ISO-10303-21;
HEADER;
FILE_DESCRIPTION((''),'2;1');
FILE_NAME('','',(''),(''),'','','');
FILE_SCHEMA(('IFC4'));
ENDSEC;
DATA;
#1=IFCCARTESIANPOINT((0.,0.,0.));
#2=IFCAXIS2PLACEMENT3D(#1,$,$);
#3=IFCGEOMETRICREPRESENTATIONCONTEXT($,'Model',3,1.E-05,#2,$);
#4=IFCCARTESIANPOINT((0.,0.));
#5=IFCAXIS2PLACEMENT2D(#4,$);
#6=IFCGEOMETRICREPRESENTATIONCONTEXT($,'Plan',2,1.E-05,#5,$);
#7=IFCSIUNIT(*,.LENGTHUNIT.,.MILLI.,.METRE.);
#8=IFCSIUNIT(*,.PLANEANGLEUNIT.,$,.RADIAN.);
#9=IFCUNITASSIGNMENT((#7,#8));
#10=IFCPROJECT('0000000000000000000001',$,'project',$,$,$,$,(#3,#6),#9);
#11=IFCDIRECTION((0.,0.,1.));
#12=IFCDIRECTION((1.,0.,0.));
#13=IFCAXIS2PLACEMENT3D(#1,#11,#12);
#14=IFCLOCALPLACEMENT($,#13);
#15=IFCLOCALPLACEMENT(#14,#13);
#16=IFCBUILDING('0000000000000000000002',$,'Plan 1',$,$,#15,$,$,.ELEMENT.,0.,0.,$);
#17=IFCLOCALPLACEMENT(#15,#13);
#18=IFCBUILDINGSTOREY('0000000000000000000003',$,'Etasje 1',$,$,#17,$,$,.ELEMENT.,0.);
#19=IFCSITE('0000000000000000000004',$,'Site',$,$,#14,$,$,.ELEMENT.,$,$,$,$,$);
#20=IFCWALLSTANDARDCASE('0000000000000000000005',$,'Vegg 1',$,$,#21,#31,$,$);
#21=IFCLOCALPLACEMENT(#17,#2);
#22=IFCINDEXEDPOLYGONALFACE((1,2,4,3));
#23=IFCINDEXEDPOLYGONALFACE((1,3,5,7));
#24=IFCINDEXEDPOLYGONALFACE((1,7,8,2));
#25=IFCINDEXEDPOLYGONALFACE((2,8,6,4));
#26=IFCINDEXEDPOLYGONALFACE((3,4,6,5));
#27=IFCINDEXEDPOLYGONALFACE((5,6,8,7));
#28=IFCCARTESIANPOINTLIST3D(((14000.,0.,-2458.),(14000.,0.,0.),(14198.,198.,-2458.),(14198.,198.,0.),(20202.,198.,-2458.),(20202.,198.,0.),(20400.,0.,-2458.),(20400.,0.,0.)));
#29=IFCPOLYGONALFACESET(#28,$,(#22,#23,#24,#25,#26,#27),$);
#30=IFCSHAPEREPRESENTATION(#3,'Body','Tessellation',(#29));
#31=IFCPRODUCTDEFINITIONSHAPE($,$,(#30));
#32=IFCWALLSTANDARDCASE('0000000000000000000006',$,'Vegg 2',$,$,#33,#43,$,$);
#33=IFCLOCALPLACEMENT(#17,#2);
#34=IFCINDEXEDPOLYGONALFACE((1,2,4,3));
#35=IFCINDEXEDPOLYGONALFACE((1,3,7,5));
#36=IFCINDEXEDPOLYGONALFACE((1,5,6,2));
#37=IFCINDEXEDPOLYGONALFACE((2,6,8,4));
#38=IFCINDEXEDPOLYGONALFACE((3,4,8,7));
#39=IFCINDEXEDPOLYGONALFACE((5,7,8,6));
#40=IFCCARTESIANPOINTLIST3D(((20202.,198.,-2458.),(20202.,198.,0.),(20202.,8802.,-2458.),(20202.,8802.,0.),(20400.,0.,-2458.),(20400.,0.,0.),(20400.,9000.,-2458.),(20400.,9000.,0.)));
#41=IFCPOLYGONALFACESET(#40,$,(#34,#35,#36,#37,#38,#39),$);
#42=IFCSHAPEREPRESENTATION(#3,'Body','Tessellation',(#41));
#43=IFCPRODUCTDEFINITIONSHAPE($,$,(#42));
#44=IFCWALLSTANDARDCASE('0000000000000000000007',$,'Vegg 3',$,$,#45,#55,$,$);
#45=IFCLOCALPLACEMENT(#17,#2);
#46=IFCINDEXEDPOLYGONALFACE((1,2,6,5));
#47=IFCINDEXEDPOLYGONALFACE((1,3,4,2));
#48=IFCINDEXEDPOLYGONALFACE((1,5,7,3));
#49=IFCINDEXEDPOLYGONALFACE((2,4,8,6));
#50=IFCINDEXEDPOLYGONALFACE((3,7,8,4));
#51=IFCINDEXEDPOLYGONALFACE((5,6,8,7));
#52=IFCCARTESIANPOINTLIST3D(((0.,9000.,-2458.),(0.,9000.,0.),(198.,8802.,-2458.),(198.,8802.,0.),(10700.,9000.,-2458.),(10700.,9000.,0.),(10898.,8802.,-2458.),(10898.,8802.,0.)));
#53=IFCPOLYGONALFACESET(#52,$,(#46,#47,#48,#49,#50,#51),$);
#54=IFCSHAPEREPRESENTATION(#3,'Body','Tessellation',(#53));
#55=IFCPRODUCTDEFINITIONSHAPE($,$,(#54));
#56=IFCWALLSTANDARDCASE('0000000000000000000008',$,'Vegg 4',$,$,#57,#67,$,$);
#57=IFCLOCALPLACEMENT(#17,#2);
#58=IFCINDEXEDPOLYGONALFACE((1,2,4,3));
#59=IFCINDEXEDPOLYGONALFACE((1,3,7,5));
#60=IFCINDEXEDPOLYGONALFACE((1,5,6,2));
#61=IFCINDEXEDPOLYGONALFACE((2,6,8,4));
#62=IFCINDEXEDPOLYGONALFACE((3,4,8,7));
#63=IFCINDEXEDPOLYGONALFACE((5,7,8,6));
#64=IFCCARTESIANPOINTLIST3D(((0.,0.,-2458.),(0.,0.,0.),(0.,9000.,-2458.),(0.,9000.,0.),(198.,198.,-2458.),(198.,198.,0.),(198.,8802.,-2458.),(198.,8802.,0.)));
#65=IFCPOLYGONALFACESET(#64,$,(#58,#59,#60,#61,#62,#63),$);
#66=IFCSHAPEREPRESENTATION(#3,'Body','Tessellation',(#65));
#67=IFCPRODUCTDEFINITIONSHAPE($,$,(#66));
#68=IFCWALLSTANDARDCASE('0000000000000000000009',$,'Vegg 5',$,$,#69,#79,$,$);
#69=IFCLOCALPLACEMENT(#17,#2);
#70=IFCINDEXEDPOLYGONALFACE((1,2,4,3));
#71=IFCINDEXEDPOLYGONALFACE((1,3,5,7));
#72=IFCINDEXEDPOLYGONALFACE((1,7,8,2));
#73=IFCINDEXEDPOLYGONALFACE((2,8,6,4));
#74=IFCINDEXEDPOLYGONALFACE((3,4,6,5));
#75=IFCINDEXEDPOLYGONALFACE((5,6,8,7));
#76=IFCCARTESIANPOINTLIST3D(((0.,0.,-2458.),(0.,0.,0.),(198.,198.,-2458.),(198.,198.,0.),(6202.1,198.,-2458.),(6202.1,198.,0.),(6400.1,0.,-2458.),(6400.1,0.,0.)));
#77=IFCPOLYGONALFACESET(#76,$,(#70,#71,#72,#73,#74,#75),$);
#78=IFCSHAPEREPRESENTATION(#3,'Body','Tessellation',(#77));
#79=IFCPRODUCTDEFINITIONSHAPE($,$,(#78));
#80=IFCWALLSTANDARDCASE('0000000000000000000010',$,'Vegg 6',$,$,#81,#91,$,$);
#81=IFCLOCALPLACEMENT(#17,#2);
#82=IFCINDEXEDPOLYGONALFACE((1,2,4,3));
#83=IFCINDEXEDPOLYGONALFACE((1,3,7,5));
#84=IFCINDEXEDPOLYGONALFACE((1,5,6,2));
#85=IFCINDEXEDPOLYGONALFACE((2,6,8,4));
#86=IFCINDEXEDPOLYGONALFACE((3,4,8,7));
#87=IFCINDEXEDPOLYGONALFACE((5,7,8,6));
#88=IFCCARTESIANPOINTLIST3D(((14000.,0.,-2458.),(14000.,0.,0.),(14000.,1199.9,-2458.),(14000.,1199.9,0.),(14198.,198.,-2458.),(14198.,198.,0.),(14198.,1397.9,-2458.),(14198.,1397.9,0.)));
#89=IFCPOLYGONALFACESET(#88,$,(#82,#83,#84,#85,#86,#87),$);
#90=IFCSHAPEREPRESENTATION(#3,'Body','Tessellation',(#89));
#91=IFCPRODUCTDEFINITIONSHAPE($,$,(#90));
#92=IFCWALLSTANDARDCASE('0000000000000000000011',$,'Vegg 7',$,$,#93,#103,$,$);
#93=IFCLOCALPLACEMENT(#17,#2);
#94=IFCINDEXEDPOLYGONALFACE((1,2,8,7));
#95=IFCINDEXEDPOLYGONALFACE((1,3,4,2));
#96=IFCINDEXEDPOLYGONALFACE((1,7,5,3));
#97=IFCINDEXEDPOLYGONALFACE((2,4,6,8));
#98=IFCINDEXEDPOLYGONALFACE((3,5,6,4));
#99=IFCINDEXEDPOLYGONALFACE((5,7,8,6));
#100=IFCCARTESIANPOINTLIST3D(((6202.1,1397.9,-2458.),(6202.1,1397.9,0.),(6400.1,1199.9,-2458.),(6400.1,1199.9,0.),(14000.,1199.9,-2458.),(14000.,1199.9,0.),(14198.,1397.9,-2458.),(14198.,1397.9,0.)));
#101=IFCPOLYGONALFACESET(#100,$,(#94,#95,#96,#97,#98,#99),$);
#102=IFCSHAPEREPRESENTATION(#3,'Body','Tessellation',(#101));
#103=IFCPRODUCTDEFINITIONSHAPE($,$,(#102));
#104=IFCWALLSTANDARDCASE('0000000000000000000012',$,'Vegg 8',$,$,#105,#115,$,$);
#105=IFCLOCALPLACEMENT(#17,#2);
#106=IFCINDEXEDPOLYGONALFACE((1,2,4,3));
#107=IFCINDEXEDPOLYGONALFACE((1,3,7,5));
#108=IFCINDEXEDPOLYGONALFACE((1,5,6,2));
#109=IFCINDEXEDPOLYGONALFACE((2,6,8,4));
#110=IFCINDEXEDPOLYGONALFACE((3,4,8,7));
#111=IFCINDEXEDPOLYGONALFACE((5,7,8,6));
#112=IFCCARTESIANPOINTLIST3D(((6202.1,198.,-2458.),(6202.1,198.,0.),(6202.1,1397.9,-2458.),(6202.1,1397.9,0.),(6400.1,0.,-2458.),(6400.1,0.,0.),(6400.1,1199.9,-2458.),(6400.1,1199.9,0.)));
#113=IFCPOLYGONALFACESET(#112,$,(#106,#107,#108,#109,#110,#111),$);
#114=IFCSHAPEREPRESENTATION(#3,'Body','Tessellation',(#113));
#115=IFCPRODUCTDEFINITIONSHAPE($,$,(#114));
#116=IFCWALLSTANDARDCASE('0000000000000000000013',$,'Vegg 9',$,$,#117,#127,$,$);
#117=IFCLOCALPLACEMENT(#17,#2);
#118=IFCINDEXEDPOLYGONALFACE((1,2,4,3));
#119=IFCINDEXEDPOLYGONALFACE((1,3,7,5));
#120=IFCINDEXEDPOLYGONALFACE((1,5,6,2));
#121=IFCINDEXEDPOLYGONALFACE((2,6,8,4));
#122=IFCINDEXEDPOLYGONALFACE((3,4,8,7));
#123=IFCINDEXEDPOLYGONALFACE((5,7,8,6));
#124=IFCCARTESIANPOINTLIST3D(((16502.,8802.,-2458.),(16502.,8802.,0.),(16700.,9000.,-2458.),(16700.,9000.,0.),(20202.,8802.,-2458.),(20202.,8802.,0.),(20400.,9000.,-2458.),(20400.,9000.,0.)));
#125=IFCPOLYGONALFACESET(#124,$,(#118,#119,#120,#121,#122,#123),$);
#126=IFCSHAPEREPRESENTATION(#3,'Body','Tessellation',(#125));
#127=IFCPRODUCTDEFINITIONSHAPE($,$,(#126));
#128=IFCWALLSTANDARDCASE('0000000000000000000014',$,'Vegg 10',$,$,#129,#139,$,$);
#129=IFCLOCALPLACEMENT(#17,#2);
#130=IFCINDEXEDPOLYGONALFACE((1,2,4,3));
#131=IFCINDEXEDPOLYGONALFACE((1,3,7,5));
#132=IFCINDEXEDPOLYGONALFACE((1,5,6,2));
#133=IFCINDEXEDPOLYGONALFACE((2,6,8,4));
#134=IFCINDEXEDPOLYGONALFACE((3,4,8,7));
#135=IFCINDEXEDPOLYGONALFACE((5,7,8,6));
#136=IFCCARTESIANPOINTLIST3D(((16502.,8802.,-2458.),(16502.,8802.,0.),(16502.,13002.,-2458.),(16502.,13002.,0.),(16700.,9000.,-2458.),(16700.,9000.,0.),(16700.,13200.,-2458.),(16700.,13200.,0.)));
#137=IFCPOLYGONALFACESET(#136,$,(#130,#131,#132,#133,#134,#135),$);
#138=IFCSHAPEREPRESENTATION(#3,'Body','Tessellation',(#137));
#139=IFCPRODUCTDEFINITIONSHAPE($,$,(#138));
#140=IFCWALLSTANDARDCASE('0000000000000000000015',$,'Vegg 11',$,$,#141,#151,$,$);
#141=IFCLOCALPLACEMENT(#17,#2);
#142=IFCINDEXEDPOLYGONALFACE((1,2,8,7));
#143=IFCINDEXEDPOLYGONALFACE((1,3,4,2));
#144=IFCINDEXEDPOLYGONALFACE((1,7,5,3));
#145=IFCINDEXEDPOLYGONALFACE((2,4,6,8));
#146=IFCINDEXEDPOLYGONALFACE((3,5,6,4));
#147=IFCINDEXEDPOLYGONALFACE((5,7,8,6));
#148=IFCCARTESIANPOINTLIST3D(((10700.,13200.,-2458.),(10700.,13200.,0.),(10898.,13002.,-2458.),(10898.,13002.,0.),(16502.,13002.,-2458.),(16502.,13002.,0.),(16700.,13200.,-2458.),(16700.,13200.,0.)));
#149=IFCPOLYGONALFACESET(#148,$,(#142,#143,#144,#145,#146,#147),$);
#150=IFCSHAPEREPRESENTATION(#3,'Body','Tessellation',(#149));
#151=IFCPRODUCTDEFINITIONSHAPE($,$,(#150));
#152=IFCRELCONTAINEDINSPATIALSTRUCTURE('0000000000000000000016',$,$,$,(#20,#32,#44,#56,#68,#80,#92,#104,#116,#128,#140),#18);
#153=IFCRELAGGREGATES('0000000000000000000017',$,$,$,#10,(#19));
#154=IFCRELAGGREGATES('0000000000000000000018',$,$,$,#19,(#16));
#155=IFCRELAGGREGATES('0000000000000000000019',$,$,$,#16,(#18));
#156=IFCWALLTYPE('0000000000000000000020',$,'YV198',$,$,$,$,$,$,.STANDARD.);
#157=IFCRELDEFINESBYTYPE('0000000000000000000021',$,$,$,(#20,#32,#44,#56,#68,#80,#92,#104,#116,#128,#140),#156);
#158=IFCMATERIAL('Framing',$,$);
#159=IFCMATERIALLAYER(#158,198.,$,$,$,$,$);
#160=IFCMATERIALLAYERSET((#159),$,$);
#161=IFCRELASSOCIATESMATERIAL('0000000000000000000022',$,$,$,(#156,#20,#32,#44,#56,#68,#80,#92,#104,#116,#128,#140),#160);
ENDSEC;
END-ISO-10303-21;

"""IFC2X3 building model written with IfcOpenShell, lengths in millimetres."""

from ifc_helpers import new_model, si_unit, frame, origin, origin_with_axes, origin_2d, place, context, project, spatial, polyline, segment, composite_curve, outline, extrude, material, layer, layer_set, layer_usage, type_object, element, save


model = new_model("IFC2X3")

# Units and contexts
model_context = context("Model", 3, precision=1e-05, world=origin())
plan_context = context("Plan", 2, precision=1e-05, world=origin_2d())
ifc_project = project(units=[si_unit("LENGTHUNIT", "METRE", prefix="MILLI"), si_unit("PLANEANGLEUNIT", "RADIAN")], contexts=[model_context, plan_context])

# Site, building, storey
site_placement = place(None, origin_with_axes())
site = spatial("IfcSite", under=ifc_project, at=site_placement, Name="Site", CompositionType="ELEMENT")
building_placement = place(site_placement, origin_with_axes())
building = spatial("IfcBuilding", under=site, at=building_placement, Name="Plan 1", CompositionType="ELEMENT", ElevationOfRefHeight=0.0, ElevationOfTerrain=0.0)
storey_placement = place(building_placement, origin_with_axes())
storey = spatial("IfcBuildingStorey", under=building, at=storey_placement, Name="Etasje 1", CompositionType="ELEMENT", Elevation=0.0)

# Walls
ifc_material = material(Name="Framing")
ifc_layer = layer(ifc_material, 198.0)
ifc_layer_set = layer_set([ifc_layer])
ifc_layer_usage_1 = layer_usage(ifc_layer_set, "AXIS2", "POSITIVE", 0.0)
wall_type = type_object("IfcWallType", Name="YV198", PredefinedType="STANDARD", material=ifc_layer_set)
wall_1_placement = place(storey_placement, frame((14000.0, 0.0, -2458.0), z_axis=(0.0, 0.0, 1.0), x_axis=(1.0, 0.0, 0.0)))
element("IfcWallStandardCase", 1, at=wall_1_placement, inside=storey, type_object=wall_type, material=ifc_layer_usage_1, Name="Vegg 1", context=model_context, shape_type="SweptSolid", body=[
    extrude(outline(composite_curve([segment(polyline([(198.0, 198.0), (0.0, 0.0)]), True, "CONTINUOUS"), segment(polyline([(0.0, 0.0), (6400.0, 0.0)]), True, "CONTINUOUS"), segment(polyline([(6400.0, 0.0), (6202.0, 198.0)]), True, "CONTINUOUS"), segment(polyline([(6202.0, 198.0), (198.0, 198.0)]), True, "CONTINUOUS")], self_intersect=False)), origin_with_axes(), (0.0, 0.0, 1.0), 2458.0),
])
ifc_layer_usage_2 = layer_usage(ifc_layer_set, "AXIS2", "POSITIVE", 0.0)
wall_2_placement = place(storey_placement, frame((20400.0, 0.0, -2458.0), z_axis=(0.0, 0.0, 1.0), x_axis=(0.0, 1.0, 0.0)))
element("IfcWallStandardCase", 2, at=wall_2_placement, inside=storey, type_object=wall_type, material=ifc_layer_usage_2, Name="Vegg 2", context=model_context, shape_type="SweptSolid", body=[
    extrude(outline(composite_curve([segment(polyline([(198.0, 198.0), (0.0, 0.0)]), True, "CONTINUOUS"), segment(polyline([(0.0, 0.0), (9000.0, 0.0)]), True, "CONTINUOUS"), segment(polyline([(9000.0, 0.0), (8802.0, 198.0)]), True, "CONTINUOUS"), segment(polyline([(8802.0, 198.0), (198.0, 198.0)]), True, "CONTINUOUS")], self_intersect=False)), origin_with_axes(), (0.0, 0.0, 1.0), 2458.0),
])
ifc_layer_usage_3 = layer_usage(ifc_layer_set, "AXIS2", "POSITIVE", 0.0)
wall_3_placement = place(storey_placement, frame((10700.0, 9000.0, -2458.0), z_axis=(0.0, 0.0, 1.0), x_axis=(-1.0, 0.0, 0.0)))
element("IfcWallStandardCase", 3, at=wall_3_placement, inside=storey, type_object=wall_type, material=ifc_layer_usage_3, Name="Vegg 3", context=model_context, shape_type="SweptSolid", body=[
    extrude(outline(composite_curve([segment(polyline([(-198.0, 198.0), (0.0, 0.0)]), True, "CONTINUOUS"), segment(polyline([(0.0, 0.0), (10700.0, 0.0)]), True, "CONTINUOUS"), segment(polyline([(10700.0, 0.0), (10502.0, 198.0)]), True, "CONTINUOUS"), segment(polyline([(10502.0, 198.0), (-198.0, 198.0)]), True, "CONTINUOUS")], self_intersect=False)), origin_with_axes(), (0.0, 0.0, 1.0), 2458.0),
])
ifc_layer_usage_4 = layer_usage(ifc_layer_set, "AXIS2", "POSITIVE", 0.0)
wall_4_placement = place(storey_placement, frame((0.0, 9000.0, -2458.0), z_axis=(0.0, 0.0, 1.0), x_axis=(0.0, -1.0, 0.0)))
element("IfcWallStandardCase", 4, at=wall_4_placement, inside=storey, type_object=wall_type, material=ifc_layer_usage_4, Name="Vegg 4", context=model_context, shape_type="SweptSolid", body=[
    extrude(outline(composite_curve([segment(polyline([(198.0, 198.0), (0.0, 0.0)]), True, "CONTINUOUS"), segment(polyline([(0.0, 0.0), (9000.0, 0.0)]), True, "CONTINUOUS"), segment(polyline([(9000.0, 0.0), (8802.0, 198.0)]), True, "CONTINUOUS"), segment(polyline([(8802.0, 198.0), (198.0, 198.0)]), True, "CONTINUOUS")], self_intersect=False)), origin_with_axes(), (0.0, 0.0, 1.0), 2458.0),
])
ifc_layer_usage_5 = layer_usage(ifc_layer_set, "AXIS2", "POSITIVE", 0.0)
wall_5_placement = place(storey_placement, frame((0.0, 0.0, -2458.0), z_axis=(0.0, 0.0, 1.0), x_axis=(1.0, 0.0, 0.0)))
element("IfcWallStandardCase", 5, at=wall_5_placement, inside=storey, type_object=wall_type, material=ifc_layer_usage_5, Name="Vegg 5", context=model_context, shape_type="SweptSolid", body=[
    extrude(outline(composite_curve([segment(polyline([(198.0, 198.0), (0.0, 0.0)]), True, "CONTINUOUS"), segment(polyline([(0.0, 0.0), (6400.1, 0.0)]), True, "CONTINUOUS"), segment(polyline([(6400.1, 0.0), (6202.1, 198.0)]), True, "CONTINUOUS"), segment(polyline([(6202.1, 198.0), (198.0, 198.0)]), True, "CONTINUOUS")], self_intersect=False)), origin_with_axes(), (0.0, 0.0, 1.0), 2458.0),
])
ifc_layer_usage_6 = layer_usage(ifc_layer_set, "AXIS2", "POSITIVE", 0.0)
wall_6_placement = place(storey_placement, frame((14000.0, 1199.9, -2458.0), z_axis=(0.0, 0.0, 1.0), x_axis=(0.0, -1.0, 0.0)))
element("IfcWallStandardCase", 6, at=wall_6_placement, inside=storey, type_object=wall_type, material=ifc_layer_usage_6, Name="Vegg 6", context=model_context, shape_type="SweptSolid", body=[
    extrude(outline(composite_curve([segment(polyline([(-198.0, 198.0), (0.0, 0.0)]), True, "CONTINUOUS"), segment(polyline([(0.0, 0.0), (1199.9, 0.0)]), True, "CONTINUOUS"), segment(polyline([(1199.9, 0.0), (1001.9, 198.0)]), True, "CONTINUOUS"), segment(polyline([(1001.9, 198.0), (-198.0, 198.0)]), True, "CONTINUOUS")], self_intersect=False)), origin_with_axes(), (0.0, 0.0, 1.0), 2458.0),
])
ifc_layer_usage_7 = layer_usage(ifc_layer_set, "AXIS2", "POSITIVE", 0.0)
wall_7_placement = place(storey_placement, frame((6400.1, 1199.9, -2458.0), z_axis=(0.0, 0.0, 1.0), x_axis=(1.0, 0.0, 0.0)))
element("IfcWallStandardCase", 7, at=wall_7_placement, inside=storey, type_object=wall_type, material=ifc_layer_usage_7, Name="Vegg 7", context=model_context, shape_type="SweptSolid", body=[
    extrude(outline(composite_curve([segment(polyline([(-198.0, 198.0), (0.0, 0.0)]), True, "CONTINUOUS"), segment(polyline([(0.0, 0.0), (7599.9, 0.0)]), True, "CONTINUOUS"), segment(polyline([(7599.9, 0.0), (7797.9, 198.0)]), True, "CONTINUOUS"), segment(polyline([(7797.9, 198.0), (-198.0, 198.0)]), True, "CONTINUOUS")], self_intersect=False)), origin_with_axes(), (0.0, 0.0, 1.0), 2458.0),
])
ifc_layer_usage_8 = layer_usage(ifc_layer_set, "AXIS2", "POSITIVE", 0.0)
wall_8_placement = place(storey_placement, frame((6400.1, 0.0, -2458.0), z_axis=(0.0, 0.0, 1.0), x_axis=(0.0, 1.0, 0.0)))
element("IfcWallStandardCase", 8, at=wall_8_placement, inside=storey, type_object=wall_type, material=ifc_layer_usage_8, Name="Vegg 8", context=model_context, shape_type="SweptSolid", body=[
    extrude(outline(composite_curve([segment(polyline([(198.0, 198.0), (0.0, 0.0)]), True, "CONTINUOUS"), segment(polyline([(0.0, 0.0), (1199.9, 0.0)]), True, "CONTINUOUS"), segment(polyline([(1199.9, 0.0), (1397.9, 198.0)]), True, "CONTINUOUS"), segment(polyline([(1397.9, 198.0), (198.0, 198.0)]), True, "CONTINUOUS")], self_intersect=False)), origin_with_axes(), (0.0, 0.0, 1.0), 2458.0),
])
ifc_layer_usage_9 = layer_usage(ifc_layer_set, "AXIS2", "POSITIVE", 0.0)
wall_9_placement = place(storey_placement, frame((20400.0, 9000.0, -2458.0), z_axis=(0.0, 0.0, 1.0), x_axis=(-1.0, 0.0, 0.0)))
element("IfcWallStandardCase", 9, at=wall_9_placement, inside=storey, type_object=wall_type, material=ifc_layer_usage_9, Name="Vegg 9", context=model_context, shape_type="SweptSolid", body=[
    extrude(outline(composite_curve([segment(polyline([(198.0, 198.0), (0.0, 0.0)]), True, "CONTINUOUS"), segment(polyline([(0.0, 0.0), (3700.0, 0.0)]), True, "CONTINUOUS"), segment(polyline([(3700.0, 0.0), (3898.0, 198.0)]), True, "CONTINUOUS"), segment(polyline([(3898.0, 198.0), (198.0, 198.0)]), True, "CONTINUOUS")], self_intersect=False)), origin_with_axes(), (0.0, 0.0, 1.0), 2458.0),
])
ifc_layer_usage_10 = layer_usage(ifc_layer_set, "AXIS2", "POSITIVE", 0.0)
wall_10_placement = place(storey_placement, frame((16700.0, 9000.0, -2458.0), z_axis=(0.0, 0.0, 1.0), x_axis=(0.0, 1.0, 0.0)))
element("IfcWallStandardCase", 10, at=wall_10_placement, inside=storey, type_object=wall_type, material=ifc_layer_usage_10, Name="Vegg 10", context=model_context, shape_type="SweptSolid", body=[
    extrude(outline(composite_curve([segment(polyline([(-198.0, 198.0), (0.0, 0.0)]), True, "CONTINUOUS"), segment(polyline([(0.0, 0.0), (4200.0, 0.0)]), True, "CONTINUOUS"), segment(polyline([(4200.0, 0.0), (4002.0, 198.0)]), True, "CONTINUOUS"), segment(polyline([(4002.0, 198.0), (-198.0, 198.0)]), True, "CONTINUOUS")], self_intersect=False)), origin_with_axes(), (0.0, 0.0, 1.0), 2458.0),
])
ifc_layer_usage_11 = layer_usage(ifc_layer_set, "AXIS2", "POSITIVE", 0.0)
wall_11_placement = place(storey_placement, frame((16700.0, 13200.0, -2458.0), z_axis=(0.0, 0.0, 1.0), x_axis=(-1.0, 0.0, 0.0)))
element("IfcWallStandardCase", 11, at=wall_11_placement, inside=storey, type_object=wall_type, material=ifc_layer_usage_11, Name="Vegg 11", context=model_context, shape_type="SweptSolid", body=[
    extrude(outline(composite_curve([segment(polyline([(198.0, 198.0), (0.0, 0.0)]), True, "CONTINUOUS"), segment(polyline([(0.0, 0.0), (6000.0, 0.0)]), True, "CONTINUOUS"), segment(polyline([(6000.0, 0.0), (5802.0, 198.0)]), True, "CONTINUOUS"), segment(polyline([(5802.0, 198.0), (198.0, 198.0)]), True, "CONTINUOUS")], self_intersect=False)), origin_with_axes(), (0.0, 0.0, 1.0), 2458.0),
])

save(model, "model.ifc")
